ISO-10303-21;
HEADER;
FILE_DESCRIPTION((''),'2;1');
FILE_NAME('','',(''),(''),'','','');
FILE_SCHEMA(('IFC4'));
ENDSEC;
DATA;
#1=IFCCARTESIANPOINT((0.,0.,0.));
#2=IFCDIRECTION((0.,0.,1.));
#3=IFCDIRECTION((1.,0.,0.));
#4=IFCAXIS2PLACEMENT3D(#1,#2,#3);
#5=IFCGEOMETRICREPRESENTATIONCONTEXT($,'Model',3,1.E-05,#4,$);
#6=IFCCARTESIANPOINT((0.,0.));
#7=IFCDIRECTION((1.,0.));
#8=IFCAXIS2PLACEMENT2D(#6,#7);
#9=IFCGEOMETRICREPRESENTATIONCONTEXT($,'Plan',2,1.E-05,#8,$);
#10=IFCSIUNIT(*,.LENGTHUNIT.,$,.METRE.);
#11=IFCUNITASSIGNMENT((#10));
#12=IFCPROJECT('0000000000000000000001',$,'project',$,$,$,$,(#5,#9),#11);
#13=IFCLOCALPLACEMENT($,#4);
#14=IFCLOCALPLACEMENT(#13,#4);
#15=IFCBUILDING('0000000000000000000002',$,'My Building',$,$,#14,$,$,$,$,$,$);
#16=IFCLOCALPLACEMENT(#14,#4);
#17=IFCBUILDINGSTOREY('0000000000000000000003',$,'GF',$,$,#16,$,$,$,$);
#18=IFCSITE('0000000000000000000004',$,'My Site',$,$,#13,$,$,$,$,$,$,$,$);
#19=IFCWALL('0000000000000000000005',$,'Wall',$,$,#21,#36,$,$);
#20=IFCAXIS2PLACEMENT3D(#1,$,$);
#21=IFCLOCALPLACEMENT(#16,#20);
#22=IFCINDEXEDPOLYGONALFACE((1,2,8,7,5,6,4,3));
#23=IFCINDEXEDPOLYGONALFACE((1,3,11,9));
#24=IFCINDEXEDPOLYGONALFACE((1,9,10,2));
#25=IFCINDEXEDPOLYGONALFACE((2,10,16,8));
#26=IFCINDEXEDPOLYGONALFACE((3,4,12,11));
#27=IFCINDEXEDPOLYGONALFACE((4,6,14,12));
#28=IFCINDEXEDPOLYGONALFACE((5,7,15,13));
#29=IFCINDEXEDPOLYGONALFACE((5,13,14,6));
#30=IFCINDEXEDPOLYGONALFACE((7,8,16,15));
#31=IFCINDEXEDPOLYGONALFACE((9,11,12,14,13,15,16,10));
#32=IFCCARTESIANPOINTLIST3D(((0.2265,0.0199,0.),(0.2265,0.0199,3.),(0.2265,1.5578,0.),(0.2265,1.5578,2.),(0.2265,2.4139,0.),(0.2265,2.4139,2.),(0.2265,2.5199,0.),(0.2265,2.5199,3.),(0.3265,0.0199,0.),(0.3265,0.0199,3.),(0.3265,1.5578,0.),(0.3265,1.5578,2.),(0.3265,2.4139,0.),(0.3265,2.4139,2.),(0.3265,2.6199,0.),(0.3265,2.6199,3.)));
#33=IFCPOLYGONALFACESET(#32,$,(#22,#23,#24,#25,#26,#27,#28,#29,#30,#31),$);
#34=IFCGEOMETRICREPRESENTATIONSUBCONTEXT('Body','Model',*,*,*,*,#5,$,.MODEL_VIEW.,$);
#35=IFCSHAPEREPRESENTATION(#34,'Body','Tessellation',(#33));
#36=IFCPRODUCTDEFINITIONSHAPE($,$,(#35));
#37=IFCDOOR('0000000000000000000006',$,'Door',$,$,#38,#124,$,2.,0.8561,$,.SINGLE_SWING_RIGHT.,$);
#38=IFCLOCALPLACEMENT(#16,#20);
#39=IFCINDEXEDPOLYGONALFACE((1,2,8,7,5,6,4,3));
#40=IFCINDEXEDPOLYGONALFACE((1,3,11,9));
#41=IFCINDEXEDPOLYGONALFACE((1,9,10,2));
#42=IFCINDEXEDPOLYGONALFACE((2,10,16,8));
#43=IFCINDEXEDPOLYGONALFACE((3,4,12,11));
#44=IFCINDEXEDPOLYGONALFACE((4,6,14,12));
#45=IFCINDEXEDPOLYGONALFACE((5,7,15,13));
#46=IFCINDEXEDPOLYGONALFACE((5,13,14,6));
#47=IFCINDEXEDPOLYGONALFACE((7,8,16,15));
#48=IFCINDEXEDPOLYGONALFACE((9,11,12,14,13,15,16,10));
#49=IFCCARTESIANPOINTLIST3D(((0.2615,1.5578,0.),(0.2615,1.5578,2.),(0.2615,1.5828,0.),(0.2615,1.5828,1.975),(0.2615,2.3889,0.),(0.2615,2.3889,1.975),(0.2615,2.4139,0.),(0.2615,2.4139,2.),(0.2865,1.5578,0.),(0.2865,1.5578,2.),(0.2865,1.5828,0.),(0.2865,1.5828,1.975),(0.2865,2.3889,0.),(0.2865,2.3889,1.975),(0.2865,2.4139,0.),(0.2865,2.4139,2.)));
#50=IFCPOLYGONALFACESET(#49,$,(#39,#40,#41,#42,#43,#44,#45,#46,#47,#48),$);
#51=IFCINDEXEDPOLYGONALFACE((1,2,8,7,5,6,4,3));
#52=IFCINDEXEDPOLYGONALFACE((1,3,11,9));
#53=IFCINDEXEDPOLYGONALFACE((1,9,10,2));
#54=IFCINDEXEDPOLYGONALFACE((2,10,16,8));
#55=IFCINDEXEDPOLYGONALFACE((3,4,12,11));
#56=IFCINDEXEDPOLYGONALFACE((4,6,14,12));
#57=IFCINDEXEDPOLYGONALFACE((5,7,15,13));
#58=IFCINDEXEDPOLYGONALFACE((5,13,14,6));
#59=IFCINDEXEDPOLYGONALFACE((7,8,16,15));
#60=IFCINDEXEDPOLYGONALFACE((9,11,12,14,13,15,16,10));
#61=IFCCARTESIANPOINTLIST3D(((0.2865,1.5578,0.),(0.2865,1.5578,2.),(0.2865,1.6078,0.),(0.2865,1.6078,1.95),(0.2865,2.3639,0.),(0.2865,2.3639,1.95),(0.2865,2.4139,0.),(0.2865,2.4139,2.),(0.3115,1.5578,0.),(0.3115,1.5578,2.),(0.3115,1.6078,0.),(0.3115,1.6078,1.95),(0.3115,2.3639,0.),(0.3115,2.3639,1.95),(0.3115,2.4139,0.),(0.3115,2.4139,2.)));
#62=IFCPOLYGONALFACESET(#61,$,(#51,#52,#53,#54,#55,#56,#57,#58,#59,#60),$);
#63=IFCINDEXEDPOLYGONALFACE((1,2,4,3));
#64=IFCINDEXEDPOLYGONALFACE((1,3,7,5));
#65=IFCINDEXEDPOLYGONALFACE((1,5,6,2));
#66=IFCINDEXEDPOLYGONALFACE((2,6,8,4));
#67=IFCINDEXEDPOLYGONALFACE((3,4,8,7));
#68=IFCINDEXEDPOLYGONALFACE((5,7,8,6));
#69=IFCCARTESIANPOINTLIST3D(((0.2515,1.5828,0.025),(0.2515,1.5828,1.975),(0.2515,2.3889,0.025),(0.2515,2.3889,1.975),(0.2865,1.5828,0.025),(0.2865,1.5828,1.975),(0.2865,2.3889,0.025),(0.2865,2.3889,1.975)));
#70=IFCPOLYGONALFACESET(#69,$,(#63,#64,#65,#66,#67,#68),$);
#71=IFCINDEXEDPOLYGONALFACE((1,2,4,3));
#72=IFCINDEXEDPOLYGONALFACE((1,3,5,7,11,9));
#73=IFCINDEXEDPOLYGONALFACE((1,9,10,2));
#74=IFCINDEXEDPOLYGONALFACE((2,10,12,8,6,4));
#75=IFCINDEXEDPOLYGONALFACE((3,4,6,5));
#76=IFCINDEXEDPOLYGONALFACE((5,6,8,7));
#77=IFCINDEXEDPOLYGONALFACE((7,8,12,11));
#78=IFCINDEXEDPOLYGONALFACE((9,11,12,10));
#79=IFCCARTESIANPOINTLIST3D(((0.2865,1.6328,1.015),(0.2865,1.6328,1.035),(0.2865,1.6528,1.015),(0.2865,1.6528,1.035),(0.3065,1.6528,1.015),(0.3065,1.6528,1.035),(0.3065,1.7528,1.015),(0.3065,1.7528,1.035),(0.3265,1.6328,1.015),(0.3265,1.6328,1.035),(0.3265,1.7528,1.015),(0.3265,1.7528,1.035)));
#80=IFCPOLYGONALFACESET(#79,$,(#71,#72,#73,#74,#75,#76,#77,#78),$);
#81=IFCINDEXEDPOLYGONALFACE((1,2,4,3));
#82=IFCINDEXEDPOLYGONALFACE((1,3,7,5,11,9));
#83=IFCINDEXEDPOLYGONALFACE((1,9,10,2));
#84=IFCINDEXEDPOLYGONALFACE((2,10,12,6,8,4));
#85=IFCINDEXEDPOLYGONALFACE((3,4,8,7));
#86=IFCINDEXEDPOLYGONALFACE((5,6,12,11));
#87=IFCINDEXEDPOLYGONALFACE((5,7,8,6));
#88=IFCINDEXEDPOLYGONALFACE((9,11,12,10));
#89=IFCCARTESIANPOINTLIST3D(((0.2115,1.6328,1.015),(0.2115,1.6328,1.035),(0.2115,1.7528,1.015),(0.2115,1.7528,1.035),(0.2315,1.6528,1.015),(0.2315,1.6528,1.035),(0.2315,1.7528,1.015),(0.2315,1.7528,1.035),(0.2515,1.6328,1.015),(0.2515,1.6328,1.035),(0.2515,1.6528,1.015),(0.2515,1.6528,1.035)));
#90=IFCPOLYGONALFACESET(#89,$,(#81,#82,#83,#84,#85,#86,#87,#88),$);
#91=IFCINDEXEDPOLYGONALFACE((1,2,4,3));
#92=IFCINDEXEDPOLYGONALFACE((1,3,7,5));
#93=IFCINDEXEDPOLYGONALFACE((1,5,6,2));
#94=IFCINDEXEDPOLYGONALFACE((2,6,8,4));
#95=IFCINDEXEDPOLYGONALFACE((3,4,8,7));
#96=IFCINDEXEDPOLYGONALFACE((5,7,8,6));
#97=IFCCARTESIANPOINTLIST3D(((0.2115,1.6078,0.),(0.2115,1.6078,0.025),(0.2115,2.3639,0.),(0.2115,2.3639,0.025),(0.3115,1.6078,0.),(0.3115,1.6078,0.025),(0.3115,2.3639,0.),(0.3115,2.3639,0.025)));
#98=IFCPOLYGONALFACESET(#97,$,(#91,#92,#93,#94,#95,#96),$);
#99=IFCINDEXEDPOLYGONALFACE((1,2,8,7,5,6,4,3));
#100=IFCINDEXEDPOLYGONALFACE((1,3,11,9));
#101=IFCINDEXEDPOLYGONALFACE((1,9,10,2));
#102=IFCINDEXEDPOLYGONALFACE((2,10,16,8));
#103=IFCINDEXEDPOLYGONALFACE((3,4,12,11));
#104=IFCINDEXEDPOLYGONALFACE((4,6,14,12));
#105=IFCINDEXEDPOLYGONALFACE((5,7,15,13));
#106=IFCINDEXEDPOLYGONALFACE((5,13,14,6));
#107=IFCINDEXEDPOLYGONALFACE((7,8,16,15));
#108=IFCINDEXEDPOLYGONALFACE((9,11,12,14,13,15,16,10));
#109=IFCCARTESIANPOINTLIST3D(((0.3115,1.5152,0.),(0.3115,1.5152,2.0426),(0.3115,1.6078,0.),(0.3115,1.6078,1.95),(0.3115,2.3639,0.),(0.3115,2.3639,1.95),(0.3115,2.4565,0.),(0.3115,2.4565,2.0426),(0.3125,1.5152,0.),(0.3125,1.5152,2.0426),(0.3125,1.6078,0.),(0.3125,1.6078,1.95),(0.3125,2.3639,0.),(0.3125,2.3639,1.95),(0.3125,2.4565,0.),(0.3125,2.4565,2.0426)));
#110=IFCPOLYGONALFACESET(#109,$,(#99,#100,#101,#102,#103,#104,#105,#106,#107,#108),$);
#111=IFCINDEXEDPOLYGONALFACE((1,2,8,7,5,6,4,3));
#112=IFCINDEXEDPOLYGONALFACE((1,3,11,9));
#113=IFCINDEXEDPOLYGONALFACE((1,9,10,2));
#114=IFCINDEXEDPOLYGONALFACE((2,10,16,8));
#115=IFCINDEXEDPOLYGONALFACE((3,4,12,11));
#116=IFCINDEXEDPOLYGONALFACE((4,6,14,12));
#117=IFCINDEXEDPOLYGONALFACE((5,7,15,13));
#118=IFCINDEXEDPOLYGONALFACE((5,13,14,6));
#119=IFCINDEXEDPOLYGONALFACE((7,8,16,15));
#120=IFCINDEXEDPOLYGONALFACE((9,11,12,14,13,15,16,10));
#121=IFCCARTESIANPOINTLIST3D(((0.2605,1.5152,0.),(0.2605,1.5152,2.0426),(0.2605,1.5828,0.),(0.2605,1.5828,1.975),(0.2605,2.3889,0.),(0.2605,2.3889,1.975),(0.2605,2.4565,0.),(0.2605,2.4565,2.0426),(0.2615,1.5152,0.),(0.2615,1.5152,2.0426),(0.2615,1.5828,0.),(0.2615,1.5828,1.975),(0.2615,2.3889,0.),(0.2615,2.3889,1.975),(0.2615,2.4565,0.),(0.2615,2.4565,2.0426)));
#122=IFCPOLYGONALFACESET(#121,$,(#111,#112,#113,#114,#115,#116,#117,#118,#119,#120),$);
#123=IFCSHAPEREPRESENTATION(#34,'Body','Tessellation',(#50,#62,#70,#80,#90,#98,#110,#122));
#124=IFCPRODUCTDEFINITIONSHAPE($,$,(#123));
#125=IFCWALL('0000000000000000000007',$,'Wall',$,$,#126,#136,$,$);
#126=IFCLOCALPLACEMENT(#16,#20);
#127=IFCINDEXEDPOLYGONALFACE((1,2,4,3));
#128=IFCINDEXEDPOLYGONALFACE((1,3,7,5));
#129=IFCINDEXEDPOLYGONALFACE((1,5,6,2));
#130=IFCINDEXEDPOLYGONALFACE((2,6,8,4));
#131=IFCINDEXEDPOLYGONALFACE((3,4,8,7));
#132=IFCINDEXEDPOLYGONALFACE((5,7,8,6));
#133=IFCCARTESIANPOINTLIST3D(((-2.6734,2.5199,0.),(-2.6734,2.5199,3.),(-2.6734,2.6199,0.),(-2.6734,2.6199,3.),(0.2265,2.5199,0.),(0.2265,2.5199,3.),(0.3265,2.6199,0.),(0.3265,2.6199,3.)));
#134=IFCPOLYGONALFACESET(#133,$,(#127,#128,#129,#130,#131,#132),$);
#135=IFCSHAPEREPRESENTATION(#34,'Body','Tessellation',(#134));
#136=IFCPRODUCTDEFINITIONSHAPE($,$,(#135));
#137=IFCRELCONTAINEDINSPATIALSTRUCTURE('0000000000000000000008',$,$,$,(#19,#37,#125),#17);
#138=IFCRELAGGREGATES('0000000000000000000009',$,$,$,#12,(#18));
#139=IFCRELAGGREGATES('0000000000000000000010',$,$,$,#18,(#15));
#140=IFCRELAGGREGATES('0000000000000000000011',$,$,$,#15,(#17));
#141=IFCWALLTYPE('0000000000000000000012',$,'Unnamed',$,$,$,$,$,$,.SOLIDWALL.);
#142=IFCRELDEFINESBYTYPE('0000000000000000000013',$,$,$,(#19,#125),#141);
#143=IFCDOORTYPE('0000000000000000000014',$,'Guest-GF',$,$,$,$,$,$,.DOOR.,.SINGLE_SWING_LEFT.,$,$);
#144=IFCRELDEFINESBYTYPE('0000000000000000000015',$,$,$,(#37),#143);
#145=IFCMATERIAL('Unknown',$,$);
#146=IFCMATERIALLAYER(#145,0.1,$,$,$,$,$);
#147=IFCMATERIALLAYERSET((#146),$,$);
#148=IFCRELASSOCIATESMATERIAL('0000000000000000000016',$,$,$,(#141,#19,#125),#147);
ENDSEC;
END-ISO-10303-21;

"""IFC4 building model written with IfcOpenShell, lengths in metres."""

from ifc_helpers import new_model, entity, si_unit, frame, origin_with_axes, origin_2d_with_axis, place, context, subcontext, project, spatial, line, indexed_curve, outline, extrude, shape, source, transform, mapped, material, layer, layer_set, layer_usage, type_object, type_shapes, element, fill, save


model = new_model("IFC4")

# Units and contexts
model_context = context("Model", 3, precision=1e-05, world=origin_with_axes())
plan_context = context("Plan", 2, precision=1e-05, world=origin_2d_with_axis())
body_context_1 = subcontext(model_context, "Body", "Model", "MODEL_VIEW")
body_context_2 = subcontext(plan_context, "Body", "Plan", "PLAN_VIEW")
ifc_project = project(units=[si_unit("LENGTHUNIT", "METRE")], contexts=[model_context, plan_context])

# Site, building, storey
site_placement = place(None, origin_with_axes())
site = spatial("IfcSite", under=ifc_project, at=site_placement, Name="My Site")
building_placement = place(site_placement, origin_with_axes())
building = spatial("IfcBuilding", under=site, at=building_placement, Name="My Building")
storey_placement = place(building_placement, origin_with_axes())
storey = spatial("IfcBuildingStorey", under=building, at=storey_placement, Name="GF")

# Shared definitions
ifc_material = material(Name="Unknown")

# Shared definitions
ifc_layer_1 = layer(ifc_material, 0.1)
ifc_layer_set_1 = layer_set([ifc_layer_1])
wall_type = type_object("IfcWallType", Name="Unnamed", PredefinedType="SOLIDWALL", material=ifc_layer_set_1)

# Wall, opening, door
ifc_layer_usage_1 = layer_usage(ifc_layer_set_1, "AXIS2", "POSITIVE", 0.0)
wall_1_placement = place(storey_placement, frame((0.3265, 0.0199, 0.0), z_axis=(0.0, 0.0, 1.0), x_axis=(0.0, 1.0, 0.0)))
wall_1 = element("IfcWall", 1, at=wall_1_placement, inside=storey, type_object=wall_type, material=ifc_layer_usage_1, Name="Wall", context=body_context_1, shape_type="SweptSolid", body=[
    extrude(outline(indexed_curve([(0.0, 0.0), (0.0, 0.1), (2.5, 0.1), (2.6, 0.0)], segments=[line(1, 2, 3, 4, 1)])), origin_with_axes(), (0.0, 0.0, 1.0), 3.0),
])
shared_shape_1 = source(origin_with_axes(), body_context_1, "Body", "SweptSolid", [
    extrude(outline(indexed_curve([(0.0, 0.0), (0.8561, 0.0), (0.8561, 2.0), (0.0, 2.0)], segments=[line(1, 2, 3, 4, 1)])), frame((0.0, -0.6, 0.0), z_axis=(0.0, -1.0, 0.0), x_axis=(1.0, 0.0, 0.0)), (0.0, 0.0, -1.0), 1.2),
])
opening_1_placement = place(wall_1_placement, frame((1.5379, 0.015, 0.0), z_axis=(0.0, 0.0, 1.0), x_axis=(1.0, 0.0, 0.0)))
opening_1 = element("IfcOpeningElement", 2, at=opening_1_placement, cuts=wall_1, PredefinedType="OPENING", context=body_context_1, shape_type="MappedRepresentation", body=[
    mapped(shared_shape_1, transform((0.0, 0.0, 0.0), x_axis=(1.0, 0.0, 0.0), y_axis=(0.0, 1.0, 0.0), z_axis=(0.0, 0.0, 1.0), scale=1.0)),
])
door_type_1 = type_object("IfcDoorType", Name="Guest-GF", OperationType="SINGLE_SWING_LEFT", PredefinedType="DOOR")
shared_shape_2 = source(origin_with_axes(), body_context_1, "Body", "SweptSolid", [
    extrude(outline(indexed_curve([(0.0, 0.0), (0.0, 2.0), (0.8561, 2.0), (0.8561, 0.0), (0.8311, 0.0), (0.8311, 1.975), (0.025, 1.975), (0.025, 0.0)], segments=[line(1, 2, 3, 4, 5, 6, 7, 8, 1)])), frame((0.0, 0.025, 0.0), z_axis=(0.0, -1.0, 0.0), x_axis=(1.0, 0.0, 0.0)), (0.0, 0.0, -1.0), 0.025),
    extrude(outline(indexed_curve([(0.0, 0.0), (0.0, 2.0), (0.8561, 2.0), (0.8561, 0.0), (0.8061, 0.0), (0.8061, 1.95), (0.05, 1.95), (0.05, 0.0)], segments=[line(1, 2, 3, 4, 5, 6, 7, 8, 1)])), frame((0.0, 0.0, 0.0), z_axis=(0.0, -1.0, 0.0), x_axis=(1.0, 0.0, 0.0)), (0.0, 0.0, -1.0), 0.025),
    extrude(outline(indexed_curve([(0.0, 0.0), (0.8061, 0.0), (0.8061, 0.035), (0.0, 0.035)], segments=[line(1, 2, 3, 4, 1)])), frame((0.025, 0.025, 0.025), z_axis=(0.0, 0.0, 1.0), x_axis=(1.0, 0.0, 0.0)), (0.0, 0.0, 1.0), 1.95),
    extrude(outline(indexed_curve([(0.0, 0.0), (0.0, -0.04), (0.12, -0.04), (0.12, -0.02), (0.02, -0.02), (0.02, 0.0)], segments=[line(1, 2, 3, 4, 5, 6, 1)])), frame((0.075, 0.025, 1.015), z_axis=(0.0, 0.0, 1.0), x_axis=(1.0, 0.0, 0.0)), (0.0, 0.0, 1.0), 0.02),
    extrude(outline(indexed_curve([(0.0, 0.0), (0.0, 0.04), (0.12, 0.04), (0.12, 0.02), (0.02, 0.02), (0.02, 0.0)], segments=[line(1, 2, 3, 4, 5, 6, 1)])), frame((0.075, 0.06, 1.015), z_axis=(0.0, 0.0, 1.0), x_axis=(1.0, 0.0, 0.0)), (0.0, 0.0, 1.0), 0.02),
    extrude(outline(indexed_curve([(0.0, 0.0), (0.7561, 0.0), (0.7561, 0.1), (0.0, 0.1)], segments=[line(1, 2, 3, 4, 1)])), frame((0.05, 0.0, 0.0), z_axis=(0.0, 0.0, 1.0), x_axis=(1.0, 0.0, 0.0)), (0.0, 0.0, 1.0), 0.025),
    extrude(outline(indexed_curve([(0.0, 0.0), (0.0, 2.0426), (0.9413, 2.0426), (0.9413, 0.0), (0.8487, 0.0), (0.8487, 1.95), (0.0926, 1.95), (0.0926, 0.0)], segments=[line(1, 2, 3, 4, 5, 6, 7, 8, 1)])), frame((-0.0426, -0.001, 0.0), z_axis=(0.0, -1.0, 0.0), x_axis=(1.0, 0.0, 0.0)), (0.0, 0.0, -1.0), 0.001),
    extrude(outline(indexed_curve([(0.0, 0.0), (0.0, 2.0426), (0.9413, 2.0426), (0.9413, 0.0), (0.8737, 0.0), (0.8737, 1.975), (0.0676, 1.975), (0.0676, 0.0)], segments=[line(1, 2, 3, 4, 5, 6, 7, 8, 1)])), frame((-0.0426, 0.05, 0.0), z_axis=(0.0, -1.0, 0.0), x_axis=(1.0, 0.0, 0.0)), (0.0, 0.0, -1.0), 0.001),
])
shared_shape_3 = source(origin_with_axes(), body_context_2, "Body", "Curve2D", [
    entity("IfcIndexedPolyCurve", entity("IfcCartesianPointList2D", [[0.0, 0.0], [0.0, 0.05], [0.025, 0.05], [0.025, 0.025], [0.05, 0.025], [0.05, 0.0]]), [entity("IfcLineIndex", [1, 2, 3, 4, 5, 6, 1])]),
    entity("IfcIndexedPolyCurve", entity("IfcCartesianPointList2D", [[0.8561, 0.0], [0.8561, 0.05], [0.8311, 0.05], [0.8311, 0.025], [0.8061, 0.025], [0.8061, 0.0]]), [entity("IfcLineIndex", [1, 2, 3, 4, 5, 6, 1])]),
    entity("IfcTrimmedCurve", entity("IfcEllipse", entity("IfcAxis2Placement2D", entity("IfcCartesianPoint", [0.7961, 0.05]), entity("IfcDirection", [1.0, 0.0])), 0.7711, 0.8061), [entity("IfcCartesianPoint", [0.7961, 0.8561])], [entity("IfcCartesianPoint", [0.025, 0.05])], True, "CARTESIAN"),
    entity("IfcIndexedPolyCurve", entity("IfcCartesianPointList2D", [[0.8311, 0.05], [0.7961, 0.05], [0.7961, 0.8561], [0.8311, 0.8561]]), [entity("IfcLineIndex", [1, 2, 3, 4, 1])]),
])
type_shapes(door_type_1, [shared_shape_2, shared_shape_3])
door_1_placement = place(opening_1_placement, frame((0.0, 0.0, 0.0), z_axis=(0.0, 0.0, 1.0), x_axis=(1.0, 0.0, 0.0)))
door_1 = element("IfcDoor", 3, at=door_1_placement, inside=storey, type_object=door_type_1, Name="Door", OperationType="SINGLE_SWING_RIGHT", OverallHeight=2.0, OverallWidth=0.8561, shapes=[
    shape(body_context_1, "Body", "MappedRepresentation", [mapped(shared_shape_2, transform((0.0, 0.0, 0.0), x_axis=(1.0, 0.0, 0.0), y_axis=(0.0, 1.0, 0.0), z_axis=(0.0, 0.0, 1.0), scale=1.0))]),
    shape(body_context_2, "Body", "MappedRepresentation", [mapped(shared_shape_3, transform((0.0, 0.0, 0.0), x_axis=(1.0, 0.0, 0.0), y_axis=(0.0, 1.0, 0.0), z_axis=(0.0, 0.0, 1.0), scale=1.0))]),
])
fill(opening_1, door_1)

# Wall
ifc_layer_usage_2 = layer_usage(ifc_layer_set_1, "AXIS2", "POSITIVE", 0.0)
wall_2_placement = place(storey_placement, frame((0.3265, 2.6199, 0.0), z_axis=(0.0, 0.0, 1.0), x_axis=(-1.0, 0.0, 0.0)))
element("IfcWall", 4, at=wall_2_placement, inside=storey, type_object=wall_type, material=ifc_layer_usage_2, Name="Wall", context=body_context_1, shape_type="SweptSolid", body=[
    extrude(outline(indexed_curve([(0.0, 0.0), (0.1, 0.1), (2.9999, 0.1), (2.9999, 0.0)], segments=[line(1, 2, 3, 4, 1)])), origin_with_axes(), (0.0, 0.0, 1.0), 3.0),
])

save(model, "model.ifc")
